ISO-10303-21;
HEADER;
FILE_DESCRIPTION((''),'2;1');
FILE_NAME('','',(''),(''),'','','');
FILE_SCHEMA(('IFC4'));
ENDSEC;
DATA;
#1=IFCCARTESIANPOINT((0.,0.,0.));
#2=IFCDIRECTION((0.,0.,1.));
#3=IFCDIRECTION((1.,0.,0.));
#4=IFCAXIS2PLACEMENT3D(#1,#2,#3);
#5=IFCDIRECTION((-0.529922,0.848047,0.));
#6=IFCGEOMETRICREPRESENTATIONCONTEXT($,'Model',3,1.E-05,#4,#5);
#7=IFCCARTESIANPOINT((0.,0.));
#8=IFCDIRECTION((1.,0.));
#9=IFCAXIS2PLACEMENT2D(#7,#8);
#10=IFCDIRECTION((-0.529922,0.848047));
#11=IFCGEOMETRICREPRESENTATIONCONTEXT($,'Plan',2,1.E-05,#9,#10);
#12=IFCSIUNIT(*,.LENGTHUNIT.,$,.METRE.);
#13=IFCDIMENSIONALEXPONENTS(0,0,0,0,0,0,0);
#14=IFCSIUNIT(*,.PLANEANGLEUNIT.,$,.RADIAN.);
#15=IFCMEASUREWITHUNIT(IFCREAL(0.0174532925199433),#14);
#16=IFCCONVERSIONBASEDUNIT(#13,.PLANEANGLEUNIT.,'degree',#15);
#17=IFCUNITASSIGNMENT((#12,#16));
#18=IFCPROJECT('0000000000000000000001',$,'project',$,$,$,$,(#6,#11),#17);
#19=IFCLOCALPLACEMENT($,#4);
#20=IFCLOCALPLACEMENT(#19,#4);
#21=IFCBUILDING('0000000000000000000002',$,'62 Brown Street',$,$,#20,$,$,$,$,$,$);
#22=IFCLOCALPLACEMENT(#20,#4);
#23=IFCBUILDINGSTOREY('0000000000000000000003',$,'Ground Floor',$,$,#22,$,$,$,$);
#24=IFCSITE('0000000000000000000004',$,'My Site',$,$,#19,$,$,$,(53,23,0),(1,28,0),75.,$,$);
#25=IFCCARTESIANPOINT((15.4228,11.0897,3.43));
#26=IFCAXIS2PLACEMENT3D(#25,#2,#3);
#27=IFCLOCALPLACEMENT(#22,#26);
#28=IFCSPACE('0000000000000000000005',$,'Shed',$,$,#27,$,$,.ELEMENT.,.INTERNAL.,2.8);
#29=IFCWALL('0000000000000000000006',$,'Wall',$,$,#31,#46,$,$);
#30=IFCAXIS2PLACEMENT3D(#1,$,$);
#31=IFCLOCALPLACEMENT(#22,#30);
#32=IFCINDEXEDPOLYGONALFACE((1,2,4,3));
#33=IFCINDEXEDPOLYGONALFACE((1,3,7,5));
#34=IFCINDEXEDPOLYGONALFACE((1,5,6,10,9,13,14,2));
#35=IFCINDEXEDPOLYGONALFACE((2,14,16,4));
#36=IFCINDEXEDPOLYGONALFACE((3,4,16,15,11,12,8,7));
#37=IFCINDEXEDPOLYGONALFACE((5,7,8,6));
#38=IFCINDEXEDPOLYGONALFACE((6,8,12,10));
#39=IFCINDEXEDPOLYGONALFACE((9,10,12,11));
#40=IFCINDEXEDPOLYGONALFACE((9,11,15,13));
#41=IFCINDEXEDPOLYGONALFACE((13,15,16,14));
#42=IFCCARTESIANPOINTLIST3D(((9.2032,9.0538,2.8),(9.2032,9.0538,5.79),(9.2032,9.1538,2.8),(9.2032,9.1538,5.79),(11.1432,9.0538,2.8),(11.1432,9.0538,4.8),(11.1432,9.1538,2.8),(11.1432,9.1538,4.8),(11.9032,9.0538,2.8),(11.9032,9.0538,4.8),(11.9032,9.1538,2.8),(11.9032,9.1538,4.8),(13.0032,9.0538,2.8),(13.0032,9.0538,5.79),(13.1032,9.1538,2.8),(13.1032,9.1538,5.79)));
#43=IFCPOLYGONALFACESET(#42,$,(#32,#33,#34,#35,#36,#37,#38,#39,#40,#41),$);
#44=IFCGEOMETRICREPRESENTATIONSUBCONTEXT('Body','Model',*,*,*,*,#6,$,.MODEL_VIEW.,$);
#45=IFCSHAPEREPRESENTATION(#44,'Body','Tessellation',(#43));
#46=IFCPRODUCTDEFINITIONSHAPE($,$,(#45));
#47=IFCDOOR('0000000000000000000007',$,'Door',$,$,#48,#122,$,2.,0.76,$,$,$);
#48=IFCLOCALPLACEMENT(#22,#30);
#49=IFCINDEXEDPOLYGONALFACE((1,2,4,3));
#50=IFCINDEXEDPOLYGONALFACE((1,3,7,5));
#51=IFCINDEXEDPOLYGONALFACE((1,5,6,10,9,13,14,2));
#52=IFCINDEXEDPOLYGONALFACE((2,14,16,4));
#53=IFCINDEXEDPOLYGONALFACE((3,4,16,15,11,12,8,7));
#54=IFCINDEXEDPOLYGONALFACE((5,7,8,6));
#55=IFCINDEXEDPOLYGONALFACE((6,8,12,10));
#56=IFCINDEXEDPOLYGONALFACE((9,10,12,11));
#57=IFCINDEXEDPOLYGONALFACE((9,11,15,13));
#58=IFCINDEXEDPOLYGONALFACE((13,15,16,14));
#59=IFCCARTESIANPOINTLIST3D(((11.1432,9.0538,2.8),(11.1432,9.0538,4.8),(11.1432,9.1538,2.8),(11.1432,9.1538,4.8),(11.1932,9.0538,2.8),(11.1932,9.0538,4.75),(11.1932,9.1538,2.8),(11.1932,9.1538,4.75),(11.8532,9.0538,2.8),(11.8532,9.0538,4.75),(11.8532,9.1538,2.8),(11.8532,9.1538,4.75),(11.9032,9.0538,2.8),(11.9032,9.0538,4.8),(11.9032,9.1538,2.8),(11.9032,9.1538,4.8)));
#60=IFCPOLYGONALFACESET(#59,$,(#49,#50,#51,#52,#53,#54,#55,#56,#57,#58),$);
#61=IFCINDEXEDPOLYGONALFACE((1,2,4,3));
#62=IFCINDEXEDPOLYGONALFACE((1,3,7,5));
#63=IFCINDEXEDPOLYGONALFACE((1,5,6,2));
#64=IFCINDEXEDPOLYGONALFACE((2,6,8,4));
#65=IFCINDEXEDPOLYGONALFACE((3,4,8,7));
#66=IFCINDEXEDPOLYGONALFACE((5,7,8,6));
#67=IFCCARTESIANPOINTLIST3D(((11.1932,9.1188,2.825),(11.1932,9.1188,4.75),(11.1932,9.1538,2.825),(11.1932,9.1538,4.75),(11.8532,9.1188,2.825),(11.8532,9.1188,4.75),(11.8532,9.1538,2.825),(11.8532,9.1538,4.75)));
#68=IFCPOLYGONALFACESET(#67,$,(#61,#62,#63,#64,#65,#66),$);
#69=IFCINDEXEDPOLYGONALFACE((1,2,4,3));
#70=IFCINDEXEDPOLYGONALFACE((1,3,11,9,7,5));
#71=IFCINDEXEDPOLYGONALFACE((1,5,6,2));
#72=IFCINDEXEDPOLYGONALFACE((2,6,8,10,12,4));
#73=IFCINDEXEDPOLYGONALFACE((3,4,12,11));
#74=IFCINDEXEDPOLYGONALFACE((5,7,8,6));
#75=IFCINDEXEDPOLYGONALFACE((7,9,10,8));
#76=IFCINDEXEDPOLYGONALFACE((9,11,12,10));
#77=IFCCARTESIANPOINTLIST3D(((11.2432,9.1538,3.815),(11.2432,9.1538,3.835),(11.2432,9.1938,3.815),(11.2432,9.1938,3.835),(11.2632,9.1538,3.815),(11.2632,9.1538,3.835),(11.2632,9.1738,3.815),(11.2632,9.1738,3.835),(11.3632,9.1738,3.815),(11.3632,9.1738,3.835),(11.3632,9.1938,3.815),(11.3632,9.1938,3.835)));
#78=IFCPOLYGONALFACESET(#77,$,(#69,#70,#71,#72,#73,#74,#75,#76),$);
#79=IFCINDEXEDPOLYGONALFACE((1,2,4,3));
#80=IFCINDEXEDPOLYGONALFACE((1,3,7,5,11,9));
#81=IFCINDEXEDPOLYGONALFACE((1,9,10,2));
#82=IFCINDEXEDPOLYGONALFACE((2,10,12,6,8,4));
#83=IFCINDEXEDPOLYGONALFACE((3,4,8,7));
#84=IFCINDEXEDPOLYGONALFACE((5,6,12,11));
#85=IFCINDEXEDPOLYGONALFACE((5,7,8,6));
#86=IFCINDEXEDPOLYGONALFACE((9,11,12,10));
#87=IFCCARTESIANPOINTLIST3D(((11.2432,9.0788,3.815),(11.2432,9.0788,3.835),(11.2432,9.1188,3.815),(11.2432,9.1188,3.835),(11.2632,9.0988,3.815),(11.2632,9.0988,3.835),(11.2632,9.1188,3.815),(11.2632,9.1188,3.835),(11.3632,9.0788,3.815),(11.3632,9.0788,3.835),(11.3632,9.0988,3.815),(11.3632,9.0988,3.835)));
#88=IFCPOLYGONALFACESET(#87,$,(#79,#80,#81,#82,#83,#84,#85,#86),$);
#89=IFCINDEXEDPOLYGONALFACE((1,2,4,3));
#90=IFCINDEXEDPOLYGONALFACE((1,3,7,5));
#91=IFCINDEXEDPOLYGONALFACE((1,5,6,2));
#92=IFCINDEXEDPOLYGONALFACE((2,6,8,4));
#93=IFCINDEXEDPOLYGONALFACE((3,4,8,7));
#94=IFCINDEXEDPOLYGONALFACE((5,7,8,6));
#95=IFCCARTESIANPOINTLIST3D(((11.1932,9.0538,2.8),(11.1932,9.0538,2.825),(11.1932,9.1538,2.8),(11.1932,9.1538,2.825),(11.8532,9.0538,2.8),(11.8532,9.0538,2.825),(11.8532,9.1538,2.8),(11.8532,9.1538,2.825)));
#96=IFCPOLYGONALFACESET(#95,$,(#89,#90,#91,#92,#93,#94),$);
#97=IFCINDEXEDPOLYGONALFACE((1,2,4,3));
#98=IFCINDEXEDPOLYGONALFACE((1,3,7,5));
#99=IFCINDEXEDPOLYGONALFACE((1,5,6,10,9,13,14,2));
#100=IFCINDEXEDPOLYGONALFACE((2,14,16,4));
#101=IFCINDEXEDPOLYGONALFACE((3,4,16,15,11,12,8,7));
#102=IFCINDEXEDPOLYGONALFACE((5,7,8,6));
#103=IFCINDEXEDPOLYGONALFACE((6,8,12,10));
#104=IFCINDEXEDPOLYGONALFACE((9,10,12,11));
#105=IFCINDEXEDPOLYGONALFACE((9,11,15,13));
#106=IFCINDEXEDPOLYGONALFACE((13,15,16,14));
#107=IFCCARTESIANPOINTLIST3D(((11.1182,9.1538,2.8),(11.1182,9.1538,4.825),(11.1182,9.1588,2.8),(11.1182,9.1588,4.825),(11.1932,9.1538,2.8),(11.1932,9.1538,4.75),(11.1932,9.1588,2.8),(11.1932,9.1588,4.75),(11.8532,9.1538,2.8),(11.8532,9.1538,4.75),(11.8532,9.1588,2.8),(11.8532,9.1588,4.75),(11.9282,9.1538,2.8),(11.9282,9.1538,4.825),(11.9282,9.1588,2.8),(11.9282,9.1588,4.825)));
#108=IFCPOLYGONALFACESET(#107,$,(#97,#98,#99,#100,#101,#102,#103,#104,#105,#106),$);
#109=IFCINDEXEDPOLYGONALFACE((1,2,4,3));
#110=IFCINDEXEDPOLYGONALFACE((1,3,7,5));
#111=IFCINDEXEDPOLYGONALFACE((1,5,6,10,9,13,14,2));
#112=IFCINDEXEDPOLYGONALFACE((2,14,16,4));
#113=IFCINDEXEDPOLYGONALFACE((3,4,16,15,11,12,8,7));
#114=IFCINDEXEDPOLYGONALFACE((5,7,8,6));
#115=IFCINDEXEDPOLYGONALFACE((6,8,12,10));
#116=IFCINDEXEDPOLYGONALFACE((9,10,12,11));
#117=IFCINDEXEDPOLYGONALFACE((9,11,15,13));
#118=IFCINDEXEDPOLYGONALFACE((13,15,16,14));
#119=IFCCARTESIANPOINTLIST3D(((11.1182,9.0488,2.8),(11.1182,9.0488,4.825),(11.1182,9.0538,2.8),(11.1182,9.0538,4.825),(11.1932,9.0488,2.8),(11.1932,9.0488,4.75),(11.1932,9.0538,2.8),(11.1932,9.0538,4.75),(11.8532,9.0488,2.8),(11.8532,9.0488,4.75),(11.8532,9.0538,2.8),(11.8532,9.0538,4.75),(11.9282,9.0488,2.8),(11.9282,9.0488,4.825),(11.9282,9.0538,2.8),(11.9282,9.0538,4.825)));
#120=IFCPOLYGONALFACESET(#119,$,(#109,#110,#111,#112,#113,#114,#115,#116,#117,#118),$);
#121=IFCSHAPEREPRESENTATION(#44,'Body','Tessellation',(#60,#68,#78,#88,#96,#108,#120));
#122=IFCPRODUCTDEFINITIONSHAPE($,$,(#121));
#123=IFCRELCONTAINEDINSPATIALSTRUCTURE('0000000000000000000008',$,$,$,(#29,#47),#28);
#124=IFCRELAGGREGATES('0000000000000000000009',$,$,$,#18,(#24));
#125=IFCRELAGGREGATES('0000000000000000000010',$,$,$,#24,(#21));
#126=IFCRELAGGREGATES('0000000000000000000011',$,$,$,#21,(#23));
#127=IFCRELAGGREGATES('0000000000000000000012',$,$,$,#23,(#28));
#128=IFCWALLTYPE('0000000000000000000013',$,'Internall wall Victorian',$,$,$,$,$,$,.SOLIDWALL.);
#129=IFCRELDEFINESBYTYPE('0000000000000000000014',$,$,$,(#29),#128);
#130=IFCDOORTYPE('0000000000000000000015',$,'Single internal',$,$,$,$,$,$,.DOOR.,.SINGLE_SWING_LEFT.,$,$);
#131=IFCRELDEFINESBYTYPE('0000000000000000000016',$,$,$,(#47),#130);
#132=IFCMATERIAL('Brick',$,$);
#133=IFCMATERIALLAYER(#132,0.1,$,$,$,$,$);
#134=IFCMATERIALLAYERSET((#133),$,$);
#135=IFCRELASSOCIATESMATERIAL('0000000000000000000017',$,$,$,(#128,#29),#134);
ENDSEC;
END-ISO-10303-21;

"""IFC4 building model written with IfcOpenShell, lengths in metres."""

from ifc_helpers import new_model, entity, si_unit, converted_unit, direction, frame, origin_with_axes, origin_2d_with_axis, place, context, subcontext, project, spatial, line, indexed_curve, outline, extrude, clip, halfspace, shape, source, transform, mapped, material, layer, layer_set, layer_usage, type_object, type_shapes, element, fill, save


model = new_model("IFC4")

# Units and contexts
model_context = context("Model", 3, precision=1e-05, world=origin_with_axes(), true_north=direction((-0.529922, 0.848047, 0.0)))
plan_context = context("Plan", 2, precision=1e-05, world=origin_2d_with_axis(), true_north=direction((-0.529922, 0.848047)))
body_context_1 = subcontext(model_context, "Body", "Model", "MODEL_VIEW")
body_context_2 = subcontext(plan_context, "Body", "Plan", "PLAN_VIEW")
ifc_project = project(units=[si_unit("LENGTHUNIT", "METRE"), converted_unit("PLANEANGLEUNIT", "degree", entity("IfcReal", 0.0174532925199433), si_unit("PLANEANGLEUNIT", "RADIAN"), dimensions=[0, 0, 0, 0, 0, 0, 0])], contexts=[model_context, plan_context])

# Site, building, storey
site_placement = place(None, origin_with_axes())
site = spatial("IfcSite", under=ifc_project, at=site_placement, Name="My Site", RefLatitude=(53, 23, 0), RefLongitude=(1, 28, 0), RefElevation=75.0)
building_placement = place(site_placement, origin_with_axes())
building = spatial("IfcBuilding", under=site, at=building_placement, Name="62 Brown Street")
storey_placement = place(building_placement, origin_with_axes())
storey = spatial("IfcBuildingStorey", under=building, at=storey_placement, Name="Ground Floor")

# Shared definitions
space_1_placement = place(storey_placement, frame((15.4228, 11.0897, 3.43), z_axis=(0.0, 0.0, 1.0), x_axis=(1.0, 0.0, 0.0)))
space_1 = spatial("IfcSpace", under=storey, at=space_1_placement, Name="Shed", CompositionType="ELEMENT", PredefinedType="INTERNAL", ElevationWithFlooring=2.8)

# Shared definitions
ifc_material_1 = material(Name="Brick")
ifc_layer_1 = layer(ifc_material_1, 0.1)
ifc_layer_set_1 = layer_set([ifc_layer_1])
wall_type_1 = type_object("IfcWallType", Name="Internall wall Victorian", PredefinedType="SOLIDWALL", material=ifc_layer_set_1)

# Wall, opening, door
ifc_layer_usage_1 = layer_usage(ifc_layer_set_1, "AXIS2", "POSITIVE", 0.0)
wall_1_placement = place(None, frame((13.1032, 9.1538, 2.8), z_axis=(0.0, 0.0, 1.0), x_axis=(-1.0, 0.0, 0.0)))
wall_1 = element("IfcWall", 1, at=wall_1_placement, inside=space_1, type_object=wall_type_1, material=ifc_layer_usage_1, Name="Wall", context=body_context_1, shape_type="Clipping", body=[
    clip(extrude(outline(indexed_curve([(0.0, 0.0), (0.0, 0.1), (3.9, 0.1), (3.9, 0.0), (0.0, 0.0)], self_intersect=False)), origin_with_axes(), (0.0, 0.0, 1.0), 2.99), halfspace(frame((0.0, 0.0, -2.8), z_axis=(-0.707104, 0.70711, 0.0), x_axis=(0.70711, 0.707104, 0.0)), False)),
])
shared_shape_1 = source(origin_with_axes(), body_context_1, "Body", "SweptSolid", [
    extrude(outline(indexed_curve([(0.0, 0.0), (0.76, 0.0), (0.76, 2.0), (0.0, 2.0)], segments=[line(1, 2, 3, 4, 1)])), frame((0.0, -0.6, 0.0), z_axis=(0.0, -1.0, 0.0), x_axis=(1.0, 0.0, 0.0)), (0.0, 0.0, -1.0), 1.2),
])
opening_placement = place(wall_1_placement, frame((1.2, 0.0, 0.0), z_axis=(0.0, 0.0, 1.0), x_axis=(1.0, 0.0, 0.0)))
opening = element("IfcOpeningElement", 2, at=opening_placement, cuts=wall_1, PredefinedType="OPENING", context=body_context_1, shape_type="MappedRepresentation", body=[
    mapped(shared_shape_1, transform((0.0, 0.0, 0.0), x_axis=(1.0, 0.0, 0.0), y_axis=(0.0, 1.0, 0.0), z_axis=(0.0, 0.0, 1.0), scale=1.0)),
])
door_type = type_object("IfcDoorType", Name="Single internal", OperationType="SINGLE_SWING_LEFT", PredefinedType="DOOR")
shared_shape_2 = source(origin_with_axes(), body_context_1, "Body", "SweptSolid", [
    extrude(outline(indexed_curve([(0.0, 0.0), (0.0, 2.0), (0.76, 2.0), (0.76, 0.0), (0.71, 0.0), (0.71, 1.95), (0.05, 1.95), (0.05, 0.0)], segments=[line(1, 2, 3, 4, 5, 6, 7, 8, 1)])), frame((0.0, 0.0, 0.0), z_axis=(0.0, -1.0, 0.0), x_axis=(1.0, 0.0, 0.0)), (0.0, 0.0, -1.0), 0.1),
    extrude(outline(indexed_curve([(0.0, 0.0), (0.66, 0.0), (0.66, 0.035), (0.0, 0.035)], segments=[line(1, 2, 3, 4, 1)])), frame((0.05, 0.0, 0.025), z_axis=(0.0, 0.0, 1.0), x_axis=(1.0, 0.0, 0.0)), (0.0, 0.0, 1.0), 1.925),
    extrude(outline(indexed_curve([(0.0, 0.0), (0.0, -0.04), (-0.12, -0.04), (-0.12, -0.02), (-0.02, -0.02), (-0.02, 0.0)], segments=[line(1, 2, 3, 4, 5, 6, 1)])), frame((0.66, 0.0, 1.015), z_axis=(0.0, 0.0, 1.0), x_axis=(1.0, 0.0, 0.0)), (0.0, 0.0, 1.0), 0.02),
    extrude(outline(indexed_curve([(0.0, 0.0), (0.0, 0.04), (-0.12, 0.04), (-0.12, 0.02), (-0.02, 0.02), (-0.02, 0.0)], segments=[line(1, 2, 3, 4, 5, 6, 1)])), frame((0.66, 0.035, 1.015), z_axis=(0.0, 0.0, 1.0), x_axis=(1.0, 0.0, 0.0)), (0.0, 0.0, 1.0), 0.02),
    extrude(outline(indexed_curve([(0.0, 0.0), (0.66, 0.0), (0.66, 0.1), (0.0, 0.1)], segments=[line(1, 2, 3, 4, 1)])), frame((0.05, 0.0, 0.0), z_axis=(0.0, 0.0, 1.0), x_axis=(1.0, 0.0, 0.0)), (0.0, 0.0, 1.0), 0.025),
    extrude(outline(indexed_curve([(0.0, 0.0), (0.0, 2.025), (0.81, 2.025), (0.81, 0.0), (0.735, 0.0), (0.735, 1.95), (0.075, 1.95), (0.075, 0.0)], segments=[line(1, 2, 3, 4, 5, 6, 7, 8, 1)])), frame((-0.025, -0.005, 0.0), z_axis=(0.0, -1.0, 0.0), x_axis=(1.0, 0.0, 0.0)), (0.0, 0.0, -1.0), 0.005),
    extrude(outline(indexed_curve([(0.0, 0.0), (0.0, 2.025), (0.81, 2.025), (0.81, 0.0), (0.735, 0.0), (0.735, 1.95), (0.075, 1.95), (0.075, 0.0)], segments=[line(1, 2, 3, 4, 5, 6, 7, 8, 1)])), frame((-0.025, 0.1, 0.0), z_axis=(0.0, -1.0, 0.0), x_axis=(1.0, 0.0, 0.0)), (0.0, 0.0, -1.0), 0.005),
])
shared_shape_3 = source(origin_with_axes(), body_context_2, "Body", "Curve2D", [
    entity("IfcIndexedPolyCurve", entity("IfcCartesianPointList2D", [[0.0, 0.0], [0.05, 0.0], [0.05, 0.1], [0.0, 0.1]]), [entity("IfcLineIndex", [1, 2, 3, 4, 1])]),
    entity("IfcIndexedPolyCurve", entity("IfcCartesianPointList2D", [[0.76, 0.0], [0.71, 0.0], [0.71, 0.1], [0.76, 0.1]]), [entity("IfcLineIndex", [1, 2, 3, 4, 1])]),
    entity("IfcTrimmedCurve", entity("IfcEllipse", entity("IfcAxis2Placement2D", entity("IfcCartesianPoint", [0.085, 0.1]), entity("IfcDirection", [1.0, 0.0])), 0.625, 0.66), [entity("IfcCartesianPoint", [0.71, 0.1])], [entity("IfcCartesianPoint", [0.085, 0.76])], True, "CARTESIAN"),
    entity("IfcIndexedPolyCurve", entity("IfcCartesianPointList2D", [[0.05, 0.1], [0.085, 0.1], [0.085, 0.76], [0.05, 0.76]]), [entity("IfcLineIndex", [1, 2, 3, 4, 1])]),
])
type_shapes(door_type, [shared_shape_2, shared_shape_3])
door_placement = place(opening_placement, frame((0.0, 0.0, 0.0), z_axis=(0.0, 0.0, 1.0), x_axis=(1.0, 0.0, 0.0)))
door = element("IfcDoor", 3, at=door_placement, inside=space_1, type_object=door_type, Name="Door", OverallHeight=2.0, OverallWidth=0.76, shapes=[
    shape(body_context_1, "Body", "MappedRepresentation", [mapped(shared_shape_2, transform((0.0, 0.0, 0.0), x_axis=(1.0, 0.0, 0.0), y_axis=(0.0, 1.0, 0.0), z_axis=(0.0, 0.0, 1.0), scale=1.0))]),
    shape(body_context_2, "Body", "MappedRepresentation", [mapped(shared_shape_3, transform((0.0, 0.0, 0.0), x_axis=(1.0, 0.0, 0.0), y_axis=(0.0, 1.0, 0.0), z_axis=(0.0, 0.0, 1.0), scale=1.0))]),
])
fill(opening, door)

save(model, "model.ifc")
